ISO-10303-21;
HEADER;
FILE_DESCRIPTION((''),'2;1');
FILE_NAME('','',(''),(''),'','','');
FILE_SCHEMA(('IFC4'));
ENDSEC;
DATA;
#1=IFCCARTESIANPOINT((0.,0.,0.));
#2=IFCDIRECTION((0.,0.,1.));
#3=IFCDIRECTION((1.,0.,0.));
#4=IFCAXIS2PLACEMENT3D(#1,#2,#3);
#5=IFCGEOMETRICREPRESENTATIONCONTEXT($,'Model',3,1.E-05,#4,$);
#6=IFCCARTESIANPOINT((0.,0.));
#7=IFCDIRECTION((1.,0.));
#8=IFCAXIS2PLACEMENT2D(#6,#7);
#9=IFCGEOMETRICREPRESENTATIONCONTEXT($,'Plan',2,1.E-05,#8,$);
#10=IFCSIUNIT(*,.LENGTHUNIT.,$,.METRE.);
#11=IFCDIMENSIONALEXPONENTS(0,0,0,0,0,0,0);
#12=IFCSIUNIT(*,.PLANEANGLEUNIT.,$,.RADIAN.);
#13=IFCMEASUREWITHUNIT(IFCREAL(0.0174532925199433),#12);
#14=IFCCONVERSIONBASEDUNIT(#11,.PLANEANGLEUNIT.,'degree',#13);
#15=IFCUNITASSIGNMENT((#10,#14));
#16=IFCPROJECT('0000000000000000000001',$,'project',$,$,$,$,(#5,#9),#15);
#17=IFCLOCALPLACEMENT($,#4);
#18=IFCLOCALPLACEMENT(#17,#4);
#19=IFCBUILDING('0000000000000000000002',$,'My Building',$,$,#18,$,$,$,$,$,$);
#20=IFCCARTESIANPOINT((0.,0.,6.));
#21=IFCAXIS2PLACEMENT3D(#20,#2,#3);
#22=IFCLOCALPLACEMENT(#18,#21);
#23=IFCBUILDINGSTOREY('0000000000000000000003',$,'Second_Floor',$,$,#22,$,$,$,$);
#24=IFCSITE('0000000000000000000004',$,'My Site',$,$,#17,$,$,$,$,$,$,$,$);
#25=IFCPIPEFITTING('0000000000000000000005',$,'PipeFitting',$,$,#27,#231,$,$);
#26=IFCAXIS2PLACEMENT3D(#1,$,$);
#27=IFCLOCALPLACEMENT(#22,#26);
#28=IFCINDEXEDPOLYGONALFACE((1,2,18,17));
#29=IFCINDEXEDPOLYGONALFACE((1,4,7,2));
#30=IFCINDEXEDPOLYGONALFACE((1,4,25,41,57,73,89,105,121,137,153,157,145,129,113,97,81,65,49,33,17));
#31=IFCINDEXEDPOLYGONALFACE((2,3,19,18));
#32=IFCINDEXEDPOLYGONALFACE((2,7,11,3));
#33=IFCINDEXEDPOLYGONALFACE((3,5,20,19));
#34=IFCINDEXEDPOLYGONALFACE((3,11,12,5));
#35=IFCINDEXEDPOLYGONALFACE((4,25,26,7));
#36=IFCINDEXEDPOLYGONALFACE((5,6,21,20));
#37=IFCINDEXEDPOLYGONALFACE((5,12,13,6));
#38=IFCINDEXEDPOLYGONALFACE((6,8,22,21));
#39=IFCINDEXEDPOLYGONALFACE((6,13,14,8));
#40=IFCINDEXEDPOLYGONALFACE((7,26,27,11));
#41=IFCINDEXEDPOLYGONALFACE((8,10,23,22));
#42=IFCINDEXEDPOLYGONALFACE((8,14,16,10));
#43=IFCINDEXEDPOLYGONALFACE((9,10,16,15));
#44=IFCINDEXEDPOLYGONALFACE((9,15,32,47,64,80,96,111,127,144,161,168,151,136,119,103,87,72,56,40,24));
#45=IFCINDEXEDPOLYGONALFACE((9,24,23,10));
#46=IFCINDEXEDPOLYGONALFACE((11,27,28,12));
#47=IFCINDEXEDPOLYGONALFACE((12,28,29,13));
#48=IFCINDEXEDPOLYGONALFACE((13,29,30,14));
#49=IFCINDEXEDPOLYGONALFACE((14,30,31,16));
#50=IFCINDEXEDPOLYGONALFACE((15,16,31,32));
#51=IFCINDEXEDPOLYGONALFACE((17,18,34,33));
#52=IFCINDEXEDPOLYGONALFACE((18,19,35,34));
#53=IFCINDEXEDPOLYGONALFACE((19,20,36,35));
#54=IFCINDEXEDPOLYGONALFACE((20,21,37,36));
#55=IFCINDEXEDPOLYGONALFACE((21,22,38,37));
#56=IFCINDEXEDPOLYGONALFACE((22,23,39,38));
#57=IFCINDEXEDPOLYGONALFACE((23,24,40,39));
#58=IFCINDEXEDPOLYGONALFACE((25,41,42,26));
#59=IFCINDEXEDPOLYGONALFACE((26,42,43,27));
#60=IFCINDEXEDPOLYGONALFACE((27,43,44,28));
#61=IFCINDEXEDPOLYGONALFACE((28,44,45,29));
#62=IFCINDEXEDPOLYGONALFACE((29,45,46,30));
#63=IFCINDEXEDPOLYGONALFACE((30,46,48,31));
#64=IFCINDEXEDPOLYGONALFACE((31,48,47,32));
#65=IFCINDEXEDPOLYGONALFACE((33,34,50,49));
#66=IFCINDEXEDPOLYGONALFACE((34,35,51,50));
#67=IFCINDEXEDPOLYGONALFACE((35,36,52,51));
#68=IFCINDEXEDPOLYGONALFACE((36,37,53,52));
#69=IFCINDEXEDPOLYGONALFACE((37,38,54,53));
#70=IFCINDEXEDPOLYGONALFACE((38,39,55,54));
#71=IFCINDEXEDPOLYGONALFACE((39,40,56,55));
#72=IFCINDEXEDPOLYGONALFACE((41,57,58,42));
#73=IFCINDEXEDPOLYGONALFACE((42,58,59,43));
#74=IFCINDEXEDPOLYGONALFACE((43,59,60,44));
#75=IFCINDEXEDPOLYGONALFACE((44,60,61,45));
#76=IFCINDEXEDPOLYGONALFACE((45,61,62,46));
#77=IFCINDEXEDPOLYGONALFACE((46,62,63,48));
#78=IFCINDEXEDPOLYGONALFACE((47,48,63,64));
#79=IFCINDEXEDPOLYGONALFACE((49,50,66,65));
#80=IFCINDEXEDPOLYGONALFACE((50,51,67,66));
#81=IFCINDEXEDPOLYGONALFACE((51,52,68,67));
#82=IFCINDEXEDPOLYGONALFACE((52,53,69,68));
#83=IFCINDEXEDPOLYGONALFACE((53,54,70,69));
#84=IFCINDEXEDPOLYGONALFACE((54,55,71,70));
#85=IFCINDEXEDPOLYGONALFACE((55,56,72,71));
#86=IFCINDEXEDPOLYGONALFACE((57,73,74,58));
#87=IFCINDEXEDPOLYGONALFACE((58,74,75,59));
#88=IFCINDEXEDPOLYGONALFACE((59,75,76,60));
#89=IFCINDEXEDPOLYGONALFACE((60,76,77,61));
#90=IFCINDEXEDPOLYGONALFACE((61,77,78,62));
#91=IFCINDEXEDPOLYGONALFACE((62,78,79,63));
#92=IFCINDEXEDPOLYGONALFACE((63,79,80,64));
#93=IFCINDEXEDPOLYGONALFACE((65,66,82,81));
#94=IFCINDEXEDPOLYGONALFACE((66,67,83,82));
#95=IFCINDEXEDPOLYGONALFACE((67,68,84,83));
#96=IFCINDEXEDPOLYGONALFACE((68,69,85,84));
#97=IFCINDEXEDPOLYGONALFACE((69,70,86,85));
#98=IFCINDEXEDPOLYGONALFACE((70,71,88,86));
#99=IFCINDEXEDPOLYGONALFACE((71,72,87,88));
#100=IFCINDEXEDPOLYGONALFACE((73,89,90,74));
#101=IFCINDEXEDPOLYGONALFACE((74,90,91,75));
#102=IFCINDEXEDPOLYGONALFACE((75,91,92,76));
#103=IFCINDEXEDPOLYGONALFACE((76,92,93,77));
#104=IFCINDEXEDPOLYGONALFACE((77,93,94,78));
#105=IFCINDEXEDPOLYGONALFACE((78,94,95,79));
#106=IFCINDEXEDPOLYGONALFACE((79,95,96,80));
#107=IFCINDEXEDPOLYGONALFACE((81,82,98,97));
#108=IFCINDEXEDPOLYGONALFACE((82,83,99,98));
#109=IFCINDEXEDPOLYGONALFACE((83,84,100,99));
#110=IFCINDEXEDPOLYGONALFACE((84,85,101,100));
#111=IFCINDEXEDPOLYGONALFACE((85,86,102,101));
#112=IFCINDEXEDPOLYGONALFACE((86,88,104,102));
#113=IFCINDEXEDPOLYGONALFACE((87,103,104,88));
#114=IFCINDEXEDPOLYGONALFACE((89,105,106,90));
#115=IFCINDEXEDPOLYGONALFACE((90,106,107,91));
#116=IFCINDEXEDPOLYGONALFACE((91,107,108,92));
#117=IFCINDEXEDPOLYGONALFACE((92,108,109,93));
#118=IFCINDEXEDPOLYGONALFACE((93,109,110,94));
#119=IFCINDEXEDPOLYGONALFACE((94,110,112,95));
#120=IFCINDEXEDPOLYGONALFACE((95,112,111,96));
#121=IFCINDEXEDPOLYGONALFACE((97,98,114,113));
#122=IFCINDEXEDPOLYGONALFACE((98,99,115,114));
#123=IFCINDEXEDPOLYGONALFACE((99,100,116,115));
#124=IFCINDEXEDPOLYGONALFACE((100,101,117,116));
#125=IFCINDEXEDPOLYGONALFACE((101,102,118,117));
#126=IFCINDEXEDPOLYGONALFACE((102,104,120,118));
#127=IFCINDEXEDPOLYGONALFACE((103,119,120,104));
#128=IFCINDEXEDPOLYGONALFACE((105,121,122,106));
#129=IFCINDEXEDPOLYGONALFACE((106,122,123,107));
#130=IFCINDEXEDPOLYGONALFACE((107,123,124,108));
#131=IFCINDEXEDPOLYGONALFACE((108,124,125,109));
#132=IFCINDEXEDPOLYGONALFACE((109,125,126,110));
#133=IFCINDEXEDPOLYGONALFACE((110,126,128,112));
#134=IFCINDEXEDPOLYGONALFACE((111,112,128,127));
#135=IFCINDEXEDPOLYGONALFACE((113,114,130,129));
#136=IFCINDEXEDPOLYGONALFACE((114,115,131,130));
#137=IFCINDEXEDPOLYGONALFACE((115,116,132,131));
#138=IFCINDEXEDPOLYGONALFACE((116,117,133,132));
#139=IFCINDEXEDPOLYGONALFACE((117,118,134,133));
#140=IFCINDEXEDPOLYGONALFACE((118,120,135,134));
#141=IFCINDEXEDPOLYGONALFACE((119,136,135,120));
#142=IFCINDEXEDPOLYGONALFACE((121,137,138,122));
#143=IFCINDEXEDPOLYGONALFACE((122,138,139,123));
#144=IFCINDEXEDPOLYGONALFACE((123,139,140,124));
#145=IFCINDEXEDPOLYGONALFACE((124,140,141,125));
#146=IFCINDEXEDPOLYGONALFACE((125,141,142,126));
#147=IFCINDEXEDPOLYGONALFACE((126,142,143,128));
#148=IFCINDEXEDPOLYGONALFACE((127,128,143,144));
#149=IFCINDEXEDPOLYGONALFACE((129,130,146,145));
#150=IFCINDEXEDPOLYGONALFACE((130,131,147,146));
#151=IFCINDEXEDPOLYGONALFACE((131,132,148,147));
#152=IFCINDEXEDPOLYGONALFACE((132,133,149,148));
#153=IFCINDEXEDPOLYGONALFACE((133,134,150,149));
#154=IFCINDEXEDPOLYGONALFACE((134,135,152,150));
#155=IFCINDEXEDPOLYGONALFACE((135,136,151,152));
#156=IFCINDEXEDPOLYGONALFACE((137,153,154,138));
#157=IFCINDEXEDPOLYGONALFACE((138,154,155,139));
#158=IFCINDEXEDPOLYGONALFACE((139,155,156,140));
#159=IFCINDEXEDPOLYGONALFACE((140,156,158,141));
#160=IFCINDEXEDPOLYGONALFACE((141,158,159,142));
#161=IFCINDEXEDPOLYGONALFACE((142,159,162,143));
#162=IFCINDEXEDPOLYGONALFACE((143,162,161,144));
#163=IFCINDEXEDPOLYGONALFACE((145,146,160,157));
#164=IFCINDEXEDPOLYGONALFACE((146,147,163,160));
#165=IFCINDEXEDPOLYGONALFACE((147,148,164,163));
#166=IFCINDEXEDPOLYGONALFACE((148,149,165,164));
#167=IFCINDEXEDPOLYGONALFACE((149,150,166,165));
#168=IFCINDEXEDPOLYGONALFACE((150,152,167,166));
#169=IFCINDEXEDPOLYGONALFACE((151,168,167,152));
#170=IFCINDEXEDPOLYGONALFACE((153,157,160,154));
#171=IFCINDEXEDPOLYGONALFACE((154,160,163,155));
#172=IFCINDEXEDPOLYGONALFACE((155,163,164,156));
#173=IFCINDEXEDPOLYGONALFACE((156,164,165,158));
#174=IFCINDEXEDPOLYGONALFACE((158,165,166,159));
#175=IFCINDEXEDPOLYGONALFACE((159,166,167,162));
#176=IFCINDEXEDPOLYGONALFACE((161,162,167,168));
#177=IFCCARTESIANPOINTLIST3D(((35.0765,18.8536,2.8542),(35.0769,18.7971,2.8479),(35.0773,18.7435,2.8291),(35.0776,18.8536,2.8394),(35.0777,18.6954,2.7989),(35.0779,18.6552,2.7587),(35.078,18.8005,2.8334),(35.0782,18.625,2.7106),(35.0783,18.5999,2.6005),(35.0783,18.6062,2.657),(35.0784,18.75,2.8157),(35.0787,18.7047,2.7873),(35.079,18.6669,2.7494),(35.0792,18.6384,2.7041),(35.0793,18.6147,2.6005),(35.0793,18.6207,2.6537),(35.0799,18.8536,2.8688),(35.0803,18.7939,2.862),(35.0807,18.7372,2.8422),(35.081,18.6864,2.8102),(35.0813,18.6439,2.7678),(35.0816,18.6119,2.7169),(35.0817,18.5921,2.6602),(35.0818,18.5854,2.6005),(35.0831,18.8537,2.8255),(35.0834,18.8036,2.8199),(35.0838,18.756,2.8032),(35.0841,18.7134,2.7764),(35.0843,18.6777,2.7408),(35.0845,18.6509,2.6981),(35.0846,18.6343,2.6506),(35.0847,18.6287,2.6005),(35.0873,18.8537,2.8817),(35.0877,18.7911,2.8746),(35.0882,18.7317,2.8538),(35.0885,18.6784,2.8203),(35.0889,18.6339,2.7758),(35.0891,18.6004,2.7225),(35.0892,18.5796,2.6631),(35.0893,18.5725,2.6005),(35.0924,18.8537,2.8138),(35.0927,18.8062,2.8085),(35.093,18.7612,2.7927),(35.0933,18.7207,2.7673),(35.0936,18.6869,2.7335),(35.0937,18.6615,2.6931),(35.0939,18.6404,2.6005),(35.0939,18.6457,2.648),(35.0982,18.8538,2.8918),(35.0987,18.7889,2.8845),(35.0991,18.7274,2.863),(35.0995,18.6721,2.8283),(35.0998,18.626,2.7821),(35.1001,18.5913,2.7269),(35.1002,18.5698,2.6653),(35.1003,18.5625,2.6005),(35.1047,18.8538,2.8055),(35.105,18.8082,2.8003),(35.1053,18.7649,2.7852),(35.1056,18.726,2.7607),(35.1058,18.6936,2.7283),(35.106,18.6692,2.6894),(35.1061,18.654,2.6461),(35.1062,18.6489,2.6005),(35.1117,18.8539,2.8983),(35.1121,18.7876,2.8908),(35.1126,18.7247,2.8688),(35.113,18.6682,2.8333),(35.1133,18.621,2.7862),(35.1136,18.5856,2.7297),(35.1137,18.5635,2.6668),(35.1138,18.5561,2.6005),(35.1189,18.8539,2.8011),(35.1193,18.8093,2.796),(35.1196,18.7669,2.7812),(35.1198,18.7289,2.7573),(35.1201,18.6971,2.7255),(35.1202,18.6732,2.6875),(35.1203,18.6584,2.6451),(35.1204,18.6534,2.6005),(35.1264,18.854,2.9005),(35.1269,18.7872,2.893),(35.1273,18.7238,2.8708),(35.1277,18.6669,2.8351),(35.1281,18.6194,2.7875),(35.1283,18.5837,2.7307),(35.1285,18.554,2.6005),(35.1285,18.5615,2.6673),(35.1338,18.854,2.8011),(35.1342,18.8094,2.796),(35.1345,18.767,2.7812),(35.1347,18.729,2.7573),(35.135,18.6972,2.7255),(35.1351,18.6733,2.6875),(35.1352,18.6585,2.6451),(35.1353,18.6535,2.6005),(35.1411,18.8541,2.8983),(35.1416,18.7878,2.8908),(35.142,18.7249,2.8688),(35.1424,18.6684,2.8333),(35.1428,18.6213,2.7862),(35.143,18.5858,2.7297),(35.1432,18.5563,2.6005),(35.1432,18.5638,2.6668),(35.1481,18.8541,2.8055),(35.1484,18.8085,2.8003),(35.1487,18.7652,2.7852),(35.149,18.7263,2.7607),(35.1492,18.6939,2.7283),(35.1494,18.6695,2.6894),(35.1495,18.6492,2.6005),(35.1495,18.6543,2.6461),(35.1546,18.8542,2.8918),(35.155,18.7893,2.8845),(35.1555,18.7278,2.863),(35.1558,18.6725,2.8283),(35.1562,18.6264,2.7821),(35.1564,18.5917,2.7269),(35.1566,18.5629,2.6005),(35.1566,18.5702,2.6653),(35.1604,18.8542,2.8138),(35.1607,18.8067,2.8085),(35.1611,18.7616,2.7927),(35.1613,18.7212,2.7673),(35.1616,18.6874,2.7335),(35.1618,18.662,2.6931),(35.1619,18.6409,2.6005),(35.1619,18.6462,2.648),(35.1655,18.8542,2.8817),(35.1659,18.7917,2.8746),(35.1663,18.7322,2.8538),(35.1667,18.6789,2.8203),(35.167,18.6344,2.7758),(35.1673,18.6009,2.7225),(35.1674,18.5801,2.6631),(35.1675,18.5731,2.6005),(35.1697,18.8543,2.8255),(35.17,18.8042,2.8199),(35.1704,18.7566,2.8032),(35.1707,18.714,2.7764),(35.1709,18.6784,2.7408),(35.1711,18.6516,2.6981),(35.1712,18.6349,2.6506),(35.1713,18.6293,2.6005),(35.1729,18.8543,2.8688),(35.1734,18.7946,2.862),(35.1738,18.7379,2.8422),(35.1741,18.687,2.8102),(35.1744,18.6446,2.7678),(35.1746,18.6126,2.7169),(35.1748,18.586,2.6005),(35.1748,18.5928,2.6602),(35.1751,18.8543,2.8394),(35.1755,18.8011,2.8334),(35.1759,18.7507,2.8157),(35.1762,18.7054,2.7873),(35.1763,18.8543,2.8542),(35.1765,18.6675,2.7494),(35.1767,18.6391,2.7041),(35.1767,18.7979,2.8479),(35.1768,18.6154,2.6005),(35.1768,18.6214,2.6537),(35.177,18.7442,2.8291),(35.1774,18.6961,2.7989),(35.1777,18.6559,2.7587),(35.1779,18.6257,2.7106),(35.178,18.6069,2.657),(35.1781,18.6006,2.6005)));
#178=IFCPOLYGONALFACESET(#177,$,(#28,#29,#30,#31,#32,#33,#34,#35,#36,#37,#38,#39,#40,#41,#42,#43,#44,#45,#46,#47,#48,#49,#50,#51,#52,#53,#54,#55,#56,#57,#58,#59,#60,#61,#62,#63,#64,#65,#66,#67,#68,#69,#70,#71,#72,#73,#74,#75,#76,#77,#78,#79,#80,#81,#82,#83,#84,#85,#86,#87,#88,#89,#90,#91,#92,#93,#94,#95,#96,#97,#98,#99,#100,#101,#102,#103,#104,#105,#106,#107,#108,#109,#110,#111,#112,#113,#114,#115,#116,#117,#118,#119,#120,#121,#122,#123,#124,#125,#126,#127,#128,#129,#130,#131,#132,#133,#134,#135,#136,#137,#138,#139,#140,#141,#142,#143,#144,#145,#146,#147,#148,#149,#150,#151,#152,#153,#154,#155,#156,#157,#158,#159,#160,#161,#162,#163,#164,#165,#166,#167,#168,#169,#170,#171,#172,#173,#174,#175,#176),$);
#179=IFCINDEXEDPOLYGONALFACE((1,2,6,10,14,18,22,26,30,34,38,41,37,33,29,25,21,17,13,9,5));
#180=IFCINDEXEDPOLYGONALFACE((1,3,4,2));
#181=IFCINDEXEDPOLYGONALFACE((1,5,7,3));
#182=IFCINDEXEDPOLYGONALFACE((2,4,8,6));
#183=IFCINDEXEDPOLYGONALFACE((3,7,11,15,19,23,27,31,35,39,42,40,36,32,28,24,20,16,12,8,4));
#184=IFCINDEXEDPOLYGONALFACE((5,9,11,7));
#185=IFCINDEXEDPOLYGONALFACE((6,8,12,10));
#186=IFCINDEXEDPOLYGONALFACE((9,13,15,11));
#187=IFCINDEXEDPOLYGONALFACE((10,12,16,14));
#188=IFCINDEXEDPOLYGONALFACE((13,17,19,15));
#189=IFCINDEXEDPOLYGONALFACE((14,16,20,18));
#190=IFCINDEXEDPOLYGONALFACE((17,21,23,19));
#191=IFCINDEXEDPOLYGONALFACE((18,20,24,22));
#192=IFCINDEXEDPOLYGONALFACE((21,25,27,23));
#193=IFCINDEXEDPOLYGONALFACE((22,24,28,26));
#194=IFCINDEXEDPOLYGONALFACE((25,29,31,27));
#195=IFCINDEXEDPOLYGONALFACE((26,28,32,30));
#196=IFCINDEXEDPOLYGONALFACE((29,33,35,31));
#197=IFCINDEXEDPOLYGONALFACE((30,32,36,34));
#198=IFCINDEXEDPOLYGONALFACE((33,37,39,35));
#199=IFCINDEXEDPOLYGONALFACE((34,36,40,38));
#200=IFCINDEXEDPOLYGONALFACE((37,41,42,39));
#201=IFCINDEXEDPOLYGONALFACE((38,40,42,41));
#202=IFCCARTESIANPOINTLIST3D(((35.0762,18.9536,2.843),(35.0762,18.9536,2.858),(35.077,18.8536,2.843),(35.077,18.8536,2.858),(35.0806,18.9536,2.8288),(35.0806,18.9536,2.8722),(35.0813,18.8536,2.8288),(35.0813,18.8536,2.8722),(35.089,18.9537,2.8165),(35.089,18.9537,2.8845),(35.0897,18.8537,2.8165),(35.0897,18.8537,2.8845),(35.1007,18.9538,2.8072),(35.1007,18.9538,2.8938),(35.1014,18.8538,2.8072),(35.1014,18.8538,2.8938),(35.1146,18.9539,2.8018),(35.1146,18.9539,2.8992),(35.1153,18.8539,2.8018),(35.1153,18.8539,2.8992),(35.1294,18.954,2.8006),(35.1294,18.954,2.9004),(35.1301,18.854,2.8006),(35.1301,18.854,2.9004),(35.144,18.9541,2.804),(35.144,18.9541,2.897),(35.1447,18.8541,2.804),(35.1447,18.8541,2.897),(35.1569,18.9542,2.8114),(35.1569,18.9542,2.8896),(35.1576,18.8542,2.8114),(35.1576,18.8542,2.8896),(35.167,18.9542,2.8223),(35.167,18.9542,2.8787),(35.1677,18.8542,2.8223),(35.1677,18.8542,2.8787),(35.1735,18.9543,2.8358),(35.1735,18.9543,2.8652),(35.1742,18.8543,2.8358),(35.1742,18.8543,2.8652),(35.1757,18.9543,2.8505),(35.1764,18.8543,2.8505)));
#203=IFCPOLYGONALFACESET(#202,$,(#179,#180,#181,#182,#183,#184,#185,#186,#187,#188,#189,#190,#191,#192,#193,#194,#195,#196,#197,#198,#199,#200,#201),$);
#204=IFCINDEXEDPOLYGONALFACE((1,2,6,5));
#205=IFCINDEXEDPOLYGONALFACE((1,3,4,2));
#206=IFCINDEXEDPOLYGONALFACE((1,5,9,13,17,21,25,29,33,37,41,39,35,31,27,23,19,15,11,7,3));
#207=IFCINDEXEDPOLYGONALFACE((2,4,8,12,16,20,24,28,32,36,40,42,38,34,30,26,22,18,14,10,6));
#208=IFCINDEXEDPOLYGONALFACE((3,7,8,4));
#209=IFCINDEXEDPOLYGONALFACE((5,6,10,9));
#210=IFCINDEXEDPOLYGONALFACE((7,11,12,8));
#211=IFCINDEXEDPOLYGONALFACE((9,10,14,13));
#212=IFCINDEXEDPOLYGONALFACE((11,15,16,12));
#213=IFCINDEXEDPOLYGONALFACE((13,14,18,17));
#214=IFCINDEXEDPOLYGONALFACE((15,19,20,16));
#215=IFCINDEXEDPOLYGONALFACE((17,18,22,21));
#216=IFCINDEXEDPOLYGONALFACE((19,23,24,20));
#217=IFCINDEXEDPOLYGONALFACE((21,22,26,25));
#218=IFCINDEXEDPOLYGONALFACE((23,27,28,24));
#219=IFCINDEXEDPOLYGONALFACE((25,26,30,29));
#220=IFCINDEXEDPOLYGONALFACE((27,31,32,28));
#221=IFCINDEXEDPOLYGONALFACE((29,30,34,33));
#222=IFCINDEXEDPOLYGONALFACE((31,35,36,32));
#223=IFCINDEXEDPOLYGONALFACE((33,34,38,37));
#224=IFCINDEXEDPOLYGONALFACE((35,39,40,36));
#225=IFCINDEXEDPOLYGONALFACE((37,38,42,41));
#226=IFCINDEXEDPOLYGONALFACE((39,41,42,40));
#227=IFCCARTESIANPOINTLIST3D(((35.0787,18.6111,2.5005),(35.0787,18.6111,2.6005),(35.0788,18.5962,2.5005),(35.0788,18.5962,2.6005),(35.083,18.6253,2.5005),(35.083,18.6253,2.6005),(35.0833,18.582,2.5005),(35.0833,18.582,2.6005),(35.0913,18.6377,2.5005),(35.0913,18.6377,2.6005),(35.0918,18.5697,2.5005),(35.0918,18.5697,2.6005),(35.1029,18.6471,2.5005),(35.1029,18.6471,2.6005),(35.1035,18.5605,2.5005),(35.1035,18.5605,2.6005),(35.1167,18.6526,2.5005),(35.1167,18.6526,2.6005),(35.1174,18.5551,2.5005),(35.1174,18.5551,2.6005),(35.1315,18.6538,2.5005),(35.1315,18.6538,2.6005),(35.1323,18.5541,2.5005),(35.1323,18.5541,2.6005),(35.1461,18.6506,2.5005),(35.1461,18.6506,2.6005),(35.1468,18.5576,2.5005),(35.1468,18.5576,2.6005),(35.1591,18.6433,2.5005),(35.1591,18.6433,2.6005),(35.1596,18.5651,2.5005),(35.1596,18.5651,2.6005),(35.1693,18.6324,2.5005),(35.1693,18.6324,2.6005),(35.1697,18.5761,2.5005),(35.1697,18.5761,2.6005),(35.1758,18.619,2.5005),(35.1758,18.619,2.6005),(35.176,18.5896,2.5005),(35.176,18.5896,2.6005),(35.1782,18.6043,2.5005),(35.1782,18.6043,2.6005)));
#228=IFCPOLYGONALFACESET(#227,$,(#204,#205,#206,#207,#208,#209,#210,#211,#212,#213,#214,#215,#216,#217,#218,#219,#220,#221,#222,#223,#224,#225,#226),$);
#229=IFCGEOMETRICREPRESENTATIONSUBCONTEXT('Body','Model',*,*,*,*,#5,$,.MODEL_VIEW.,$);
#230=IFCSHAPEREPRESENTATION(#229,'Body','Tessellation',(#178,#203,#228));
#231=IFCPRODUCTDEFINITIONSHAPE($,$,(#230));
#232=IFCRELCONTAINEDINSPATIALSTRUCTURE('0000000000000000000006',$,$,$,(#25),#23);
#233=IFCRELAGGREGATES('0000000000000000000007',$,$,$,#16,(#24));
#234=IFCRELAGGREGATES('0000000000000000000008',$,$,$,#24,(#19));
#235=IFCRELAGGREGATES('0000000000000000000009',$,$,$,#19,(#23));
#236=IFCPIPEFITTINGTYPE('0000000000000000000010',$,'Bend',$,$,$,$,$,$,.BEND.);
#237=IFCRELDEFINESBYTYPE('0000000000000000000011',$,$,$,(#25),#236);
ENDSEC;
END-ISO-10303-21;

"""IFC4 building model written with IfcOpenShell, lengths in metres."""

from ifc_helpers import new_model, entity, si_unit, converted_unit, frame, origin_with_axes, origin_2d_with_axis, place, context, subcontext, project, spatial, circle, extrude, source, transform, mapped, type_object, type_shapes, element, save


model = new_model("IFC4")

# Units and contexts
model_context = context("Model", 3, precision=1e-05, world=origin_with_axes())
plan_context = context("Plan", 2, precision=1e-05, world=origin_2d_with_axis())
body_context_1 = subcontext(model_context, "Body", "Model", "MODEL_VIEW")
ifc_project = project(units=[si_unit("LENGTHUNIT", "METRE"), converted_unit("PLANEANGLEUNIT", "degree", entity("IfcReal", 0.0174532925199433), si_unit("PLANEANGLEUNIT", "RADIAN"), dimensions=[0, 0, 0, 0, 0, 0, 0])], contexts=[model_context, plan_context])

# Site, building, storey
site_placement = place(None, origin_with_axes())
site = spatial("IfcSite", under=ifc_project, at=site_placement, Name="My Site")
building_placement = place(site_placement, origin_with_axes())
building = spatial("IfcBuilding", under=site, at=building_placement, Name="My Building")
storey_placement = place(building_placement, frame((0.0, 0.0, 6.0), z_axis=(0.0, 0.0, 1.0), x_axis=(1.0, 0.0, 0.0)))
storey = spatial("IfcBuildingStorey", under=building, at=storey_placement, Name="Second_Floor")

# Pipe fitting
pipe_fitting_type = type_object("IfcPipeFittingType", Name="Bend", PredefinedType="BEND")
shared_shape_1 = source(origin_with_axes(), body_context_1, "Body", "SolidModel", [
    entity("IfcSweptDiskSolid", entity("IfcIndexedPolyCurve", entity("IfcCartesianPointList3D", [[0.0, 0.0, -0.1], [0.0, 0.0732, -0.2768], [0.0, 0.25, -0.35]]), [entity("IfcArcIndex", [1, 2, 3])]), 0.05),
    extrude(circle(Radius=0.05), origin_with_axes(), (0.0, 0.0, -1.0), 0.1),
    extrude(circle(Radius=0.05), frame((0.0, 0.25, -0.35), z_axis=(0.0, 1.0, 0.0), x_axis=(1.0, 0.0, 0.0)), (0.0, 0.0, 1.0), 0.1),
])
type_shapes(pipe_fitting_type, [shared_shape_1])
for number, where, z_axis, x_axis, name in (
    (1, (35.1257, 18.954, 2.8505), (-0.007084, 0.999975, 0.0), (0.999975, 0.007084, 0.0), "PipeFitting"),
):
    element("IfcPipeFitting", number, at=place(storey_placement, frame(where, z_axis=z_axis, x_axis=x_axis)), inside=storey, type_object=pipe_fitting_type, Name=name, context=body_context_1, shape_type="MappedRepresentation", body=[
        mapped(shared_shape_1, transform((0.0, 0.0, 0.0), x_axis=(1.0, 0.0, 0.0), y_axis=(0.0, 1.0, 0.0), z_axis=(0.0, 0.0, 1.0), scale=1.0)),
    ])

save(model, "model.ifc")
